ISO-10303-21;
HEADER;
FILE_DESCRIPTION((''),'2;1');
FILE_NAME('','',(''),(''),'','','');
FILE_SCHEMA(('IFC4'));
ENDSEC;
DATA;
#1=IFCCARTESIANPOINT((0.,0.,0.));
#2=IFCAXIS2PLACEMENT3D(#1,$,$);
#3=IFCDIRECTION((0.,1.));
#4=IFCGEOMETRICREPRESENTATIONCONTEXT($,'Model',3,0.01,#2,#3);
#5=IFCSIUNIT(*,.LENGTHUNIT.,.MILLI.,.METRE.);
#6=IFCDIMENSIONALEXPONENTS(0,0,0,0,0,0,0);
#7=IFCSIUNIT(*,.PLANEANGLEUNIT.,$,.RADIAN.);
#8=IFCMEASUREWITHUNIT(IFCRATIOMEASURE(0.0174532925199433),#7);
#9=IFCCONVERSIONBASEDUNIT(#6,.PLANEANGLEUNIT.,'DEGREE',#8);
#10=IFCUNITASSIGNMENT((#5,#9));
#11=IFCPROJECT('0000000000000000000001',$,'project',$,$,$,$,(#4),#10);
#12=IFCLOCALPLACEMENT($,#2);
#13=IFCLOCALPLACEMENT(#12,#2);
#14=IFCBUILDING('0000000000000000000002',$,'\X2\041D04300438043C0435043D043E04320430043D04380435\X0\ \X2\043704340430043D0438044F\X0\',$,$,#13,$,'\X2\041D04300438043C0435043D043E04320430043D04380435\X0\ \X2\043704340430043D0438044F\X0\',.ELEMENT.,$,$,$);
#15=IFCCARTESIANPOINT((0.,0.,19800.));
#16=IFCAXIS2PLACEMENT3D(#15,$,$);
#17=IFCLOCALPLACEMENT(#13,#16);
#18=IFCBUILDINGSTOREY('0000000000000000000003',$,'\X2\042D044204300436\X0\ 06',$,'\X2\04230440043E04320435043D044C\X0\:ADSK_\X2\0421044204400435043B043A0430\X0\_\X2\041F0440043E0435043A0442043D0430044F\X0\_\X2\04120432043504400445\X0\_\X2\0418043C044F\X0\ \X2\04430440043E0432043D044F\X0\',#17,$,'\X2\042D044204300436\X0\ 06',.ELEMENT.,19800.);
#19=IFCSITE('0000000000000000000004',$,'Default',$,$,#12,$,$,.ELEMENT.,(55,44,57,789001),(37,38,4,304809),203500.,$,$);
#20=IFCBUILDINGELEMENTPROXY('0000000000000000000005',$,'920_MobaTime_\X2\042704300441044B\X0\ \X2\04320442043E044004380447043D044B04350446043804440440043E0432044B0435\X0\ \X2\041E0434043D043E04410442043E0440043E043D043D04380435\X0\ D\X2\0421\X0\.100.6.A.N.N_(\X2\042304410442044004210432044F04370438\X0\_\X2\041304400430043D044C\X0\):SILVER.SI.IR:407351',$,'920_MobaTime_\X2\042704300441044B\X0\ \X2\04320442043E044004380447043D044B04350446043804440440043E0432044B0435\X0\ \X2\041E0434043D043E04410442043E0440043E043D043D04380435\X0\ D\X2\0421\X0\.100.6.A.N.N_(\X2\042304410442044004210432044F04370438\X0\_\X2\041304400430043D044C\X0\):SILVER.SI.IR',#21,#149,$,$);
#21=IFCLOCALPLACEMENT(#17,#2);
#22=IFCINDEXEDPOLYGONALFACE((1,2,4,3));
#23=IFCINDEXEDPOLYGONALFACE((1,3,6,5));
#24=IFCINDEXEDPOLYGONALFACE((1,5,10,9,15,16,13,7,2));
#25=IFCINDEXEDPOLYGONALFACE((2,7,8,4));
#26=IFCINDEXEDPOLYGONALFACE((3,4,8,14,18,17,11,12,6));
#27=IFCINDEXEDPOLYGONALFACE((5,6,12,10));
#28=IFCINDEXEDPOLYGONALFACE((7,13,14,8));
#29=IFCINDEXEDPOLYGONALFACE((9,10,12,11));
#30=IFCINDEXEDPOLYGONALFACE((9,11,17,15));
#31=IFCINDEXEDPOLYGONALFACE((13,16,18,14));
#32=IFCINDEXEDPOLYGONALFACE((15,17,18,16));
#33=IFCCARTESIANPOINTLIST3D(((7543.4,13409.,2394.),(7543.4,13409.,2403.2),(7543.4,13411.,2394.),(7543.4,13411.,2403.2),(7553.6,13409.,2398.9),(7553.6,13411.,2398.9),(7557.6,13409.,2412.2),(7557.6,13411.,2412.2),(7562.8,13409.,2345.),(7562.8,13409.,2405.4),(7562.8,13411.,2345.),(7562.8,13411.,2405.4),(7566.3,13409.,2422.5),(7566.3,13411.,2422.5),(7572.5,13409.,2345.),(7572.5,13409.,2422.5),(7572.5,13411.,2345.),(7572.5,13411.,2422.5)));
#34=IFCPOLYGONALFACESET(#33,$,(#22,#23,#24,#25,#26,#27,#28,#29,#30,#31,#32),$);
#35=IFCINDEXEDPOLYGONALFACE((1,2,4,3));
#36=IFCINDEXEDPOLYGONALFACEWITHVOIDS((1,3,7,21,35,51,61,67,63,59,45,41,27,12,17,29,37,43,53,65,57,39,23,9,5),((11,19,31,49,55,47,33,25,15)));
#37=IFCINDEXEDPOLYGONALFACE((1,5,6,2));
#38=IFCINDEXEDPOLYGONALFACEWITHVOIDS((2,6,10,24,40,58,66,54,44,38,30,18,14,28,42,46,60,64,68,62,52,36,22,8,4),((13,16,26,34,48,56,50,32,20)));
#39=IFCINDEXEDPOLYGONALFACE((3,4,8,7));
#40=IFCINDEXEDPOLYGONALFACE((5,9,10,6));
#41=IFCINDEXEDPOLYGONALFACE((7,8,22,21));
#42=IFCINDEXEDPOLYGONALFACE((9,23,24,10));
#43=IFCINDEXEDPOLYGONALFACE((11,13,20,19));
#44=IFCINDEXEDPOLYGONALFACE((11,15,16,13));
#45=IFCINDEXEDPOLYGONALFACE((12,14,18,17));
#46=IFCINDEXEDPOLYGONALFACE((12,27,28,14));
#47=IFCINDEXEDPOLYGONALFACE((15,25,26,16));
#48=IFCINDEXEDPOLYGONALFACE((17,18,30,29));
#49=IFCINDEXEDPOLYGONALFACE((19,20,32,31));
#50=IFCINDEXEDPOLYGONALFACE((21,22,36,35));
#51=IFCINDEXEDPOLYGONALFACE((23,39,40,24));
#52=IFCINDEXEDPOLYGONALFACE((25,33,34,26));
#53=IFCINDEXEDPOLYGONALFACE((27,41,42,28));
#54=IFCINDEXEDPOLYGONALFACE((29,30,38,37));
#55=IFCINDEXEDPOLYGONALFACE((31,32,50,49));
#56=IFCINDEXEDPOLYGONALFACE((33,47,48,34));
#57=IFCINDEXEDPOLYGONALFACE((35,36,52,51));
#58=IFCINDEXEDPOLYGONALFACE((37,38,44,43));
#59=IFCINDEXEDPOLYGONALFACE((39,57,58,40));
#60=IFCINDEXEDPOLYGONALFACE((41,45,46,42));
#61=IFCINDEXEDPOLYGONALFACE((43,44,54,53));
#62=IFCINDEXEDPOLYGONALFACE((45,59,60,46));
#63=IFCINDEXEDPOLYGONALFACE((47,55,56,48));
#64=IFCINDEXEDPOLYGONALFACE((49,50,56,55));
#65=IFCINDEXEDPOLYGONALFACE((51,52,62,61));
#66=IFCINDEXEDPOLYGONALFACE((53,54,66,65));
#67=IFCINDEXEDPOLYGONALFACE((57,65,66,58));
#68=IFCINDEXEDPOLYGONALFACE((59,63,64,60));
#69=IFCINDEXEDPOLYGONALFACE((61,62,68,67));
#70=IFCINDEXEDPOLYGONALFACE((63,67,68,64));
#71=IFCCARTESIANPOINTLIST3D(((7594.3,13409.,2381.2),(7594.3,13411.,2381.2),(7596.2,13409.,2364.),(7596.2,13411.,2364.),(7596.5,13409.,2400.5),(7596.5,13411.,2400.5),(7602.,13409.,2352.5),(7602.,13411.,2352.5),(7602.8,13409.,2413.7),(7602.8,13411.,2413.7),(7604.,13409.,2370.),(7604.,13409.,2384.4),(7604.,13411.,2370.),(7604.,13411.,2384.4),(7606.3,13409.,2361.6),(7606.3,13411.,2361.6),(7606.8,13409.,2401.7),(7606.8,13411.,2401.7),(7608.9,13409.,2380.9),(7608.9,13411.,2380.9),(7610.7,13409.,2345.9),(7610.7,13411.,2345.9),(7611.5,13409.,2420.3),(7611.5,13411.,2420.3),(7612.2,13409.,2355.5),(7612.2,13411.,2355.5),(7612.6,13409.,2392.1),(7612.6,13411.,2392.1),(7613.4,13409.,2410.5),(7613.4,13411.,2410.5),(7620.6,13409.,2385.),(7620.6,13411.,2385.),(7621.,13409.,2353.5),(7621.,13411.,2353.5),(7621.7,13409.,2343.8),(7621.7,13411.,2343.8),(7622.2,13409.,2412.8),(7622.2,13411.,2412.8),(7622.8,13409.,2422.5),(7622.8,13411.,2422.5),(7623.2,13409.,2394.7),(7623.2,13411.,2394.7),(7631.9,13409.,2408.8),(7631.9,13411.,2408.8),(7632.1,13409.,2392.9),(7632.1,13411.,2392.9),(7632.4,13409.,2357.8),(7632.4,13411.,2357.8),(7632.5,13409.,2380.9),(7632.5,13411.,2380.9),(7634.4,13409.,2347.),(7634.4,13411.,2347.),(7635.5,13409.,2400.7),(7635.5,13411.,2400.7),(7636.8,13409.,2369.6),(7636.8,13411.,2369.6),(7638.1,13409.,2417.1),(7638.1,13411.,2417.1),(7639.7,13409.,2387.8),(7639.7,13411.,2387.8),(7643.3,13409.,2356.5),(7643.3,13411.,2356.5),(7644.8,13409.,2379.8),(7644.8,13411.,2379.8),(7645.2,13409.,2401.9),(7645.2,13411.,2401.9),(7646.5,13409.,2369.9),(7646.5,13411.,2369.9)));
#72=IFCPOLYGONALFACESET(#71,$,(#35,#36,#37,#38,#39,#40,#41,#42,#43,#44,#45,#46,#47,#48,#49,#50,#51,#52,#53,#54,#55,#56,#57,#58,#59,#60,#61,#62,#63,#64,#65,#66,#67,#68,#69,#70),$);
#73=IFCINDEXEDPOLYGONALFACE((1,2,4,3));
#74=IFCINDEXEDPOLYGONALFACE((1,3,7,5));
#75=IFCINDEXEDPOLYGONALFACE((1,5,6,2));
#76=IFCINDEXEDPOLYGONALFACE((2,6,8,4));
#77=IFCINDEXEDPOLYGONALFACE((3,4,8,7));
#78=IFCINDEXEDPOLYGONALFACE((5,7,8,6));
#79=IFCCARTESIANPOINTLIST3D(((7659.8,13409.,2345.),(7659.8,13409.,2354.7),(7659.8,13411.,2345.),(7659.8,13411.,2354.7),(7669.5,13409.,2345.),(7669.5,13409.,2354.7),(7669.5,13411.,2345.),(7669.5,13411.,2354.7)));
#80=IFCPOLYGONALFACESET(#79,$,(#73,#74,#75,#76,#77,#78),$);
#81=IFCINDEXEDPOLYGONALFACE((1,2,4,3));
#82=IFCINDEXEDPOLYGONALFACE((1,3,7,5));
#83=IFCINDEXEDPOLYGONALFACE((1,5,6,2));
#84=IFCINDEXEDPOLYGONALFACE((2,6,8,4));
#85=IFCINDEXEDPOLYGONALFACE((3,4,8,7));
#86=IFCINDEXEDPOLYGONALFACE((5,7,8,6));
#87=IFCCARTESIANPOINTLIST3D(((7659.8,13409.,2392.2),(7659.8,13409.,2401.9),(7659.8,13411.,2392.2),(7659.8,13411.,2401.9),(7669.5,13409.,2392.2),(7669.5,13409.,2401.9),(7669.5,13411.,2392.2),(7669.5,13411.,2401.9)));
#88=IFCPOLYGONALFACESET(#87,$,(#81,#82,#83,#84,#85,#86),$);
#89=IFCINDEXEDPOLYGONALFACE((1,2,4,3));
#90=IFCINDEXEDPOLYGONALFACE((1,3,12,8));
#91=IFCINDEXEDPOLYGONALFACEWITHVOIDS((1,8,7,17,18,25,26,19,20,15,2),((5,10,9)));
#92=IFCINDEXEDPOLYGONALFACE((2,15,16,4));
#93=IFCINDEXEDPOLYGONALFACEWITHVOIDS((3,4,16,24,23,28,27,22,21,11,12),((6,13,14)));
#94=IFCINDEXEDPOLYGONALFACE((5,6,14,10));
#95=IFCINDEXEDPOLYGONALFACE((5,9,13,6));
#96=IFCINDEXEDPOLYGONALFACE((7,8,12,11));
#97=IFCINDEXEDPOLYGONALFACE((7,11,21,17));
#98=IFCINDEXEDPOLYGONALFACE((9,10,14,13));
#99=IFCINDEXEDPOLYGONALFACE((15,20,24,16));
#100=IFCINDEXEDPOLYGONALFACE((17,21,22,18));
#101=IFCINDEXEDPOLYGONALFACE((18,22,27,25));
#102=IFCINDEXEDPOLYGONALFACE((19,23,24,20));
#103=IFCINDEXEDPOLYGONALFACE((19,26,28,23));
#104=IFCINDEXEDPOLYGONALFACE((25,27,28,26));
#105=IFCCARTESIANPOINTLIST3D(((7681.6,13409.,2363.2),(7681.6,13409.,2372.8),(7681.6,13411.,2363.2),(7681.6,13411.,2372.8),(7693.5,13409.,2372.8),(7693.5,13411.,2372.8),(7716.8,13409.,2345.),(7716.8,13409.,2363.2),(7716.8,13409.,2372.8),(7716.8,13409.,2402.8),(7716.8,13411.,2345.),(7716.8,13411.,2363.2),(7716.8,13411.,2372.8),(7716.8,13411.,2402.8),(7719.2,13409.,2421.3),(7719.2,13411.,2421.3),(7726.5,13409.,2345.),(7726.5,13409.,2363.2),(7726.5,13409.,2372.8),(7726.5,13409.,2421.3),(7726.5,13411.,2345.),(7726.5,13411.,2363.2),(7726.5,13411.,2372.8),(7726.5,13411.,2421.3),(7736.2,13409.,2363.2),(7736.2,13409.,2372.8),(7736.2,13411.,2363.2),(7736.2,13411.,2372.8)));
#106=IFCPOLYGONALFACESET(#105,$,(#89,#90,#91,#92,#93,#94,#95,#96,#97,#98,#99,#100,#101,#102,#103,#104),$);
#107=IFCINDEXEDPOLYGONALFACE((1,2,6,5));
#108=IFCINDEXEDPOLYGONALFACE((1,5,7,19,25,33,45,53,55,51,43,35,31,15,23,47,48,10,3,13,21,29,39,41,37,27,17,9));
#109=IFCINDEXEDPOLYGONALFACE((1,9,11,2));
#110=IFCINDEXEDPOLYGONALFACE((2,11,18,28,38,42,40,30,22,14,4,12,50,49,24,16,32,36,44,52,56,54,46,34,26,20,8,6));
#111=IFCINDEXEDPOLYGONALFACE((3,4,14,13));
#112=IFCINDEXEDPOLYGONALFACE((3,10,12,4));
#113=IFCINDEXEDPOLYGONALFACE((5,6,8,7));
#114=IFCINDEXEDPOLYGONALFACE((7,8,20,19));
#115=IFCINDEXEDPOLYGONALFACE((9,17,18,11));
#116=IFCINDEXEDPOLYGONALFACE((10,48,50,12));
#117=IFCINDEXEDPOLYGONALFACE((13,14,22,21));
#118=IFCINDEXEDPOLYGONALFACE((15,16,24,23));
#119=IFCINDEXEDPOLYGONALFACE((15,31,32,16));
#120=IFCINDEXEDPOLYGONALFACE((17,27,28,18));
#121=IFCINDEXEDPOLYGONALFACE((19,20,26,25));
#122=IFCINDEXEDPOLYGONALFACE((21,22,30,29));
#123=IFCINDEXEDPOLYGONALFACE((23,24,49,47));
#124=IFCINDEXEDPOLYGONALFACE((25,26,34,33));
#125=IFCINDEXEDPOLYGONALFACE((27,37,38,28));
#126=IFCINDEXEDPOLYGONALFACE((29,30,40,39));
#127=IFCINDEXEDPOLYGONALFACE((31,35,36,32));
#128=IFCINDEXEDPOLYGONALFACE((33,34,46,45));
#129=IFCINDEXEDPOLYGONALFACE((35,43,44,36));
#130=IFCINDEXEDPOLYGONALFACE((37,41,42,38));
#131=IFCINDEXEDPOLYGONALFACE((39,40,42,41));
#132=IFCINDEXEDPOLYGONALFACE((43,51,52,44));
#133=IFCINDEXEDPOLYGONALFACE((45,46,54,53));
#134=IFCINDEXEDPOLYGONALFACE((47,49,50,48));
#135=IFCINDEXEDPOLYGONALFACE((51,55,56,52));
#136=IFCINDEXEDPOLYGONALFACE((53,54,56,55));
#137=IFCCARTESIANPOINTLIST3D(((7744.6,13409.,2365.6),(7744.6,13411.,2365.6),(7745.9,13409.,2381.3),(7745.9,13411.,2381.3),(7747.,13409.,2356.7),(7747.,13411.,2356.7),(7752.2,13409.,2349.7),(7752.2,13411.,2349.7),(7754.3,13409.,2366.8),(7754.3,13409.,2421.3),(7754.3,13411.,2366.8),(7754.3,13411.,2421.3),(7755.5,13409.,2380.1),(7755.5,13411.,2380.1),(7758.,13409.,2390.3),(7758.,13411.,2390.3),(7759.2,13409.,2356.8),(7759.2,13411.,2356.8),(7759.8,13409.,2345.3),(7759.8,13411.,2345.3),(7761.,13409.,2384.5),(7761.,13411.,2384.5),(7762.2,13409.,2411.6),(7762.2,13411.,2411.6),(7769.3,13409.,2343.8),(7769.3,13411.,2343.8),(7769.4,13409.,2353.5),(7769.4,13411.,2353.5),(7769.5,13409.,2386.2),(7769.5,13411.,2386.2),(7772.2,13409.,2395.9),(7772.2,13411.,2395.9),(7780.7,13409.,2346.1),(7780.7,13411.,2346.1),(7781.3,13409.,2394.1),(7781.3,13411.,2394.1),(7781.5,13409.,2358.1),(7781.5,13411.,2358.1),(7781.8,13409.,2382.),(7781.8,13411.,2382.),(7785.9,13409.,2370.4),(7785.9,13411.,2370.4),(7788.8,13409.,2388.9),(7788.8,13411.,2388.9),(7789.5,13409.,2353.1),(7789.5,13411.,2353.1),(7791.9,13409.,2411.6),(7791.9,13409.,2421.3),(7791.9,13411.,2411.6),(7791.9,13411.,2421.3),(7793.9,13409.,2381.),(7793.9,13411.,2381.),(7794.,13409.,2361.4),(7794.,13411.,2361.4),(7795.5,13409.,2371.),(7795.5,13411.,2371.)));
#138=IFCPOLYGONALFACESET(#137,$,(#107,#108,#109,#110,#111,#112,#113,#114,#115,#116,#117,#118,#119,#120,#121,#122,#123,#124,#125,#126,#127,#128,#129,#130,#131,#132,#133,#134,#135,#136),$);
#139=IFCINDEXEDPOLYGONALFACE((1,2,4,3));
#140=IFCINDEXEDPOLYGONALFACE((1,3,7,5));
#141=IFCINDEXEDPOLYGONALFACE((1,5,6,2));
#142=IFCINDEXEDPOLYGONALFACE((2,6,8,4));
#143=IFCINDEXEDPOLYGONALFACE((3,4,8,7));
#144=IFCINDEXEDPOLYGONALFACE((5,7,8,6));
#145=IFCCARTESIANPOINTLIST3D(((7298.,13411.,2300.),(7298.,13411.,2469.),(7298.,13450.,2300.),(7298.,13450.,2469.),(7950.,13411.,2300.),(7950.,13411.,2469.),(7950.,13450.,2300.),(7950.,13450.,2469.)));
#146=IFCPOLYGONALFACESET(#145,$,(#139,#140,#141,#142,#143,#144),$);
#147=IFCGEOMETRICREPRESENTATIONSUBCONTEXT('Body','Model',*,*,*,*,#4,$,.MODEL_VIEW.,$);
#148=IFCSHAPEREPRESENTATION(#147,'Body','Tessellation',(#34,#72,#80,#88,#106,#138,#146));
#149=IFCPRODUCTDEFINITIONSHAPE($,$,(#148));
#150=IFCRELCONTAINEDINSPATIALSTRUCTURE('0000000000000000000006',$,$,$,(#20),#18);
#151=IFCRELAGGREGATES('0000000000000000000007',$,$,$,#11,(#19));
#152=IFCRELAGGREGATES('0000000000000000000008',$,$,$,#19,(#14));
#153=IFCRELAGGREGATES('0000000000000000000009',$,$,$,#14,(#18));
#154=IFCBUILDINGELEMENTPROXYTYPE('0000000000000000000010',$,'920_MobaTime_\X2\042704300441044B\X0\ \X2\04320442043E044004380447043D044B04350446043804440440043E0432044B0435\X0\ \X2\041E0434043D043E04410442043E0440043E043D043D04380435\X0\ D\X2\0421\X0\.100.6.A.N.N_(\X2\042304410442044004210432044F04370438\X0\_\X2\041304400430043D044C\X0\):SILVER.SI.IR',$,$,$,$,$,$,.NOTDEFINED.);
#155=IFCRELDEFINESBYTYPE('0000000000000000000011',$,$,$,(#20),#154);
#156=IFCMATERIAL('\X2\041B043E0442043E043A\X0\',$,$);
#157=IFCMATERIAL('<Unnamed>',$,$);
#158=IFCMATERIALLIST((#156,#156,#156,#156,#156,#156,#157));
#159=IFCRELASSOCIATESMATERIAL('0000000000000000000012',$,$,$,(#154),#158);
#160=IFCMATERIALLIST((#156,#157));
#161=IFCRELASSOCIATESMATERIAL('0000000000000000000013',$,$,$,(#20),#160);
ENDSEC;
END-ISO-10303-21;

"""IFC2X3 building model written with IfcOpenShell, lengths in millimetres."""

from ifc_helpers import new_model, entity, si_unit, converted_unit, direction, frame, origin, origin_2d_with_axis, place, context, subcontext, project, spatial, polyline, rectangle, outline, extrude, source, transform, mapped, material, material_list, type_object, type_shapes, element, save


model = new_model("IFC2X3")

# Units and contexts
model_context = context("Model", 3, precision=0.01, world=origin(), true_north=direction((0.0, 1.0)))
body_context = subcontext(model_context, "Body", "Model", "MODEL_VIEW")
ifc_project = project(units=[si_unit("LENGTHUNIT", "METRE", prefix="MILLI"), converted_unit("PLANEANGLEUNIT", "DEGREE", entity("IfcRatioMeasure", 0.0174532925199433), si_unit("PLANEANGLEUNIT", "RADIAN"), dimensions=[0, 0, 0, 0, 0, 0, 0])], contexts=[model_context])

# Site, building, storey
site_placement = place(None, frame((0.0, 0.0, 0.0)))
site = spatial("IfcSite", under=ifc_project, at=site_placement, Name="Default", CompositionType="ELEMENT", RefLatitude=(55, 44, 57, 789001), RefLongitude=(37, 38, 4, 304809), RefElevation=203500.0)
building_placement = place(site_placement, origin())
building = spatial("IfcBuilding", under=site, at=building_placement, Name="Наименование здания", LongName="Наименование здания", CompositionType="ELEMENT")
storey_placement = place(building_placement, frame((0.0, 0.0, 19800.0)))
storey = spatial("IfcBuildingStorey", under=building, at=storey_placement, Name="Этаж 06", ObjectType="Уровень:ADSK_Стрелка_Проектная_Вверх_Имя уровня", LongName="Этаж 06", CompositionType="ELEMENT", Elevation=19800.0)

# Building element proxy
ifc_material_1 = material(Name="Лоток")
ifc_material_2 = material(Name="<Unnamed>")
ifc_material_list_1 = material_list([ifc_material_1, ifc_material_1, ifc_material_1, ifc_material_1, ifc_material_1, ifc_material_1, ifc_material_2])
building_element_proxy_type_1 = type_object("IfcBuildingElementProxyType", Name="920_MobaTime_Часы вторичныецифровые Односторонние DС.100.6.A.N.N_(УстрСвязи_Грань):SILVER.SI.IR", PredefinedType="NOTDEFINED", material=ifc_material_list_1)
shared_shape_1 = source(origin(), body_context, "Body", "SweptSolid", [
    extrude(outline(polyline([(-49.3, -13.1), (28.2, -13.1), (28.2, -6.8), (17.9, 1.8), (8.9, 16.0), (-0.3, 16.0), (4.6, 5.8), (11.1, -3.4), (-49.3, -3.4), (-49.3, -13.1)])), frame((-64.6, 9.8, 39.0), z_axis=(0.0, 0.0, 1.0), x_axis=(0.0, 1.0, 0.0)), (0.0, 0.0, 1.0), 2.0),
    extrude(outline(polyline([(2.2, -27.6), (19.0, -27.6), (30.5, -16.1), (33.3, -4.9), (31.0, 5.8), (21.8, 17.2), (5.2, 27.3), (-11.1, 33.0), (-24.0, 32.7), (-33.6, 27.6), (-40.3, 18.6), (-42.8, 5.7), (-38.0, -6.3), (-27.2, -15.0), (-17.5, -17.7), (-8.2, -16.4), (-0.3, -11.9), (5.1, -4.5), (7.3, 6.2), (4.0, 17.2), (18.5, 7.3), (23.6, -2.4), (22.0, -11.4), (14.2, -18.4), (5.3, -18.3), (2.2, -27.6)]), holes=[polyline([(-9.0, 23.3), (-1.3, 14.4), (-2.6, 2.0), (-11.4, -7.0), (-23.4, -6.1), (-32.2, 2.9), (-31.2, 15.1), (-25.6, 22.1), (-17.5, 24.9), (-9.0, 23.3)])]), frame((-2.7, 3.6, 39.0), z_axis=(0.0, 0.0, 1.0), x_axis=(-0.427649, 0.903945, 0.0)), (0.0, 0.0, 1.0), 2.0),
    extrude(rectangle(XDim=9.7, YDim=9.7, at=origin_2d_with_axis()), frame((40.6, -34.7, 39.0)), (0.0, 0.0, 1.0), 2.0),
    extrude(rectangle(XDim=9.7, YDim=9.7, at=origin_2d_with_axis()), frame((40.6, 12.6, 39.0)), (0.0, 0.0, 1.0), 2.0),
    extrude(outline(polyline([(-0.9, -28.1), (8.8, -28.1), (8.8, -9.9), (18.5, -9.9), (18.5, -0.2), (8.8, -0.2), (8.8, 48.3), (1.5, 48.3), (-36.0, -0.2), (-36.0, -9.9), (-0.9, -9.9), (-0.9, -28.1)]), holes=[polyline([(-0.9, -0.2), (-24.1, -0.2), (-0.9, 29.7), (-0.9, -0.2)])]), frame((93.6, -11.4, 39.0)), (0.0, 0.0, 1.0), 2.0),
    extrude(outline(polyline([(3.3, -28.3), (12.5, -28.3), (20.5, -25.0), (26.8, -18.8), (30.7, -10.0), (31.4, 1.6), (26.9, 11.8), (20.1, 18.4), (11.1, 22.3), (1.0, 23.3), (-7.9, 20.4), (-14.9, 14.5), (-18.9, 6.2), (-17.1, -9.0), (-36.7, 0.5), (-29.1, 29.3), (-38.5, 31.7), (-48.1, -4.6), (-11.6, -23.0), (-8.0, -14.0), (-10.8, -7.6), (-10.2, 1.1), (-3.0, 11.8), (9.2, 12.8), (20.0, 5.4), (21.3, -7.5), (15.5, -16.4), (4.6, -18.6), (3.3, -28.3)])), frame((147.1, -8.5, 39.0), z_axis=(0.0, 0.0, 1.0), x_axis=(0.256974, -0.966418, 0.0)), (0.0, 0.0, 1.0), 2.0),
    extrude(rectangle(XDim=652.0, YDim=169.0, at=origin_2d_with_axis()), frame((0.0, 0.0, 0.0), z_axis=(0.0, 0.0, 1.0), x_axis=(-1.0, 0.0, 0.0)), (0.0, 0.0, 1.0), 39.0),
])
type_shapes(building_element_proxy_type_1, [shared_shape_1])
ifc_material_list_2 = material_list([ifc_material_1, ifc_material_2])
proxy_1_placement = place(storey_placement, frame((7624.0, 13450.0, 2384.5), z_axis=(0.0, -1.0, 0.0), x_axis=(1.0, 0.0, 0.0)))
element("IfcBuildingElementProxy", 1, at=proxy_1_placement, inside=storey, type_object=building_element_proxy_type_1, material=ifc_material_list_2, Name="920_MobaTime_Часы вторичныецифровые Односторонние DС.100.6.A.N.N_(УстрСвязи_Грань):SILVER.SI.IR:407351", ObjectType="920_MobaTime_Часы вторичныецифровые Односторонние DС.100.6.A.N.N_(УстрСвязи_Грань):SILVER.SI.IR", context=body_context, shape_type="MappedRepresentation", body=[
    mapped(shared_shape_1, transform((0.0, 0.0, 0.0), scale=1.0)),
])

save(model, "model.ifc")
